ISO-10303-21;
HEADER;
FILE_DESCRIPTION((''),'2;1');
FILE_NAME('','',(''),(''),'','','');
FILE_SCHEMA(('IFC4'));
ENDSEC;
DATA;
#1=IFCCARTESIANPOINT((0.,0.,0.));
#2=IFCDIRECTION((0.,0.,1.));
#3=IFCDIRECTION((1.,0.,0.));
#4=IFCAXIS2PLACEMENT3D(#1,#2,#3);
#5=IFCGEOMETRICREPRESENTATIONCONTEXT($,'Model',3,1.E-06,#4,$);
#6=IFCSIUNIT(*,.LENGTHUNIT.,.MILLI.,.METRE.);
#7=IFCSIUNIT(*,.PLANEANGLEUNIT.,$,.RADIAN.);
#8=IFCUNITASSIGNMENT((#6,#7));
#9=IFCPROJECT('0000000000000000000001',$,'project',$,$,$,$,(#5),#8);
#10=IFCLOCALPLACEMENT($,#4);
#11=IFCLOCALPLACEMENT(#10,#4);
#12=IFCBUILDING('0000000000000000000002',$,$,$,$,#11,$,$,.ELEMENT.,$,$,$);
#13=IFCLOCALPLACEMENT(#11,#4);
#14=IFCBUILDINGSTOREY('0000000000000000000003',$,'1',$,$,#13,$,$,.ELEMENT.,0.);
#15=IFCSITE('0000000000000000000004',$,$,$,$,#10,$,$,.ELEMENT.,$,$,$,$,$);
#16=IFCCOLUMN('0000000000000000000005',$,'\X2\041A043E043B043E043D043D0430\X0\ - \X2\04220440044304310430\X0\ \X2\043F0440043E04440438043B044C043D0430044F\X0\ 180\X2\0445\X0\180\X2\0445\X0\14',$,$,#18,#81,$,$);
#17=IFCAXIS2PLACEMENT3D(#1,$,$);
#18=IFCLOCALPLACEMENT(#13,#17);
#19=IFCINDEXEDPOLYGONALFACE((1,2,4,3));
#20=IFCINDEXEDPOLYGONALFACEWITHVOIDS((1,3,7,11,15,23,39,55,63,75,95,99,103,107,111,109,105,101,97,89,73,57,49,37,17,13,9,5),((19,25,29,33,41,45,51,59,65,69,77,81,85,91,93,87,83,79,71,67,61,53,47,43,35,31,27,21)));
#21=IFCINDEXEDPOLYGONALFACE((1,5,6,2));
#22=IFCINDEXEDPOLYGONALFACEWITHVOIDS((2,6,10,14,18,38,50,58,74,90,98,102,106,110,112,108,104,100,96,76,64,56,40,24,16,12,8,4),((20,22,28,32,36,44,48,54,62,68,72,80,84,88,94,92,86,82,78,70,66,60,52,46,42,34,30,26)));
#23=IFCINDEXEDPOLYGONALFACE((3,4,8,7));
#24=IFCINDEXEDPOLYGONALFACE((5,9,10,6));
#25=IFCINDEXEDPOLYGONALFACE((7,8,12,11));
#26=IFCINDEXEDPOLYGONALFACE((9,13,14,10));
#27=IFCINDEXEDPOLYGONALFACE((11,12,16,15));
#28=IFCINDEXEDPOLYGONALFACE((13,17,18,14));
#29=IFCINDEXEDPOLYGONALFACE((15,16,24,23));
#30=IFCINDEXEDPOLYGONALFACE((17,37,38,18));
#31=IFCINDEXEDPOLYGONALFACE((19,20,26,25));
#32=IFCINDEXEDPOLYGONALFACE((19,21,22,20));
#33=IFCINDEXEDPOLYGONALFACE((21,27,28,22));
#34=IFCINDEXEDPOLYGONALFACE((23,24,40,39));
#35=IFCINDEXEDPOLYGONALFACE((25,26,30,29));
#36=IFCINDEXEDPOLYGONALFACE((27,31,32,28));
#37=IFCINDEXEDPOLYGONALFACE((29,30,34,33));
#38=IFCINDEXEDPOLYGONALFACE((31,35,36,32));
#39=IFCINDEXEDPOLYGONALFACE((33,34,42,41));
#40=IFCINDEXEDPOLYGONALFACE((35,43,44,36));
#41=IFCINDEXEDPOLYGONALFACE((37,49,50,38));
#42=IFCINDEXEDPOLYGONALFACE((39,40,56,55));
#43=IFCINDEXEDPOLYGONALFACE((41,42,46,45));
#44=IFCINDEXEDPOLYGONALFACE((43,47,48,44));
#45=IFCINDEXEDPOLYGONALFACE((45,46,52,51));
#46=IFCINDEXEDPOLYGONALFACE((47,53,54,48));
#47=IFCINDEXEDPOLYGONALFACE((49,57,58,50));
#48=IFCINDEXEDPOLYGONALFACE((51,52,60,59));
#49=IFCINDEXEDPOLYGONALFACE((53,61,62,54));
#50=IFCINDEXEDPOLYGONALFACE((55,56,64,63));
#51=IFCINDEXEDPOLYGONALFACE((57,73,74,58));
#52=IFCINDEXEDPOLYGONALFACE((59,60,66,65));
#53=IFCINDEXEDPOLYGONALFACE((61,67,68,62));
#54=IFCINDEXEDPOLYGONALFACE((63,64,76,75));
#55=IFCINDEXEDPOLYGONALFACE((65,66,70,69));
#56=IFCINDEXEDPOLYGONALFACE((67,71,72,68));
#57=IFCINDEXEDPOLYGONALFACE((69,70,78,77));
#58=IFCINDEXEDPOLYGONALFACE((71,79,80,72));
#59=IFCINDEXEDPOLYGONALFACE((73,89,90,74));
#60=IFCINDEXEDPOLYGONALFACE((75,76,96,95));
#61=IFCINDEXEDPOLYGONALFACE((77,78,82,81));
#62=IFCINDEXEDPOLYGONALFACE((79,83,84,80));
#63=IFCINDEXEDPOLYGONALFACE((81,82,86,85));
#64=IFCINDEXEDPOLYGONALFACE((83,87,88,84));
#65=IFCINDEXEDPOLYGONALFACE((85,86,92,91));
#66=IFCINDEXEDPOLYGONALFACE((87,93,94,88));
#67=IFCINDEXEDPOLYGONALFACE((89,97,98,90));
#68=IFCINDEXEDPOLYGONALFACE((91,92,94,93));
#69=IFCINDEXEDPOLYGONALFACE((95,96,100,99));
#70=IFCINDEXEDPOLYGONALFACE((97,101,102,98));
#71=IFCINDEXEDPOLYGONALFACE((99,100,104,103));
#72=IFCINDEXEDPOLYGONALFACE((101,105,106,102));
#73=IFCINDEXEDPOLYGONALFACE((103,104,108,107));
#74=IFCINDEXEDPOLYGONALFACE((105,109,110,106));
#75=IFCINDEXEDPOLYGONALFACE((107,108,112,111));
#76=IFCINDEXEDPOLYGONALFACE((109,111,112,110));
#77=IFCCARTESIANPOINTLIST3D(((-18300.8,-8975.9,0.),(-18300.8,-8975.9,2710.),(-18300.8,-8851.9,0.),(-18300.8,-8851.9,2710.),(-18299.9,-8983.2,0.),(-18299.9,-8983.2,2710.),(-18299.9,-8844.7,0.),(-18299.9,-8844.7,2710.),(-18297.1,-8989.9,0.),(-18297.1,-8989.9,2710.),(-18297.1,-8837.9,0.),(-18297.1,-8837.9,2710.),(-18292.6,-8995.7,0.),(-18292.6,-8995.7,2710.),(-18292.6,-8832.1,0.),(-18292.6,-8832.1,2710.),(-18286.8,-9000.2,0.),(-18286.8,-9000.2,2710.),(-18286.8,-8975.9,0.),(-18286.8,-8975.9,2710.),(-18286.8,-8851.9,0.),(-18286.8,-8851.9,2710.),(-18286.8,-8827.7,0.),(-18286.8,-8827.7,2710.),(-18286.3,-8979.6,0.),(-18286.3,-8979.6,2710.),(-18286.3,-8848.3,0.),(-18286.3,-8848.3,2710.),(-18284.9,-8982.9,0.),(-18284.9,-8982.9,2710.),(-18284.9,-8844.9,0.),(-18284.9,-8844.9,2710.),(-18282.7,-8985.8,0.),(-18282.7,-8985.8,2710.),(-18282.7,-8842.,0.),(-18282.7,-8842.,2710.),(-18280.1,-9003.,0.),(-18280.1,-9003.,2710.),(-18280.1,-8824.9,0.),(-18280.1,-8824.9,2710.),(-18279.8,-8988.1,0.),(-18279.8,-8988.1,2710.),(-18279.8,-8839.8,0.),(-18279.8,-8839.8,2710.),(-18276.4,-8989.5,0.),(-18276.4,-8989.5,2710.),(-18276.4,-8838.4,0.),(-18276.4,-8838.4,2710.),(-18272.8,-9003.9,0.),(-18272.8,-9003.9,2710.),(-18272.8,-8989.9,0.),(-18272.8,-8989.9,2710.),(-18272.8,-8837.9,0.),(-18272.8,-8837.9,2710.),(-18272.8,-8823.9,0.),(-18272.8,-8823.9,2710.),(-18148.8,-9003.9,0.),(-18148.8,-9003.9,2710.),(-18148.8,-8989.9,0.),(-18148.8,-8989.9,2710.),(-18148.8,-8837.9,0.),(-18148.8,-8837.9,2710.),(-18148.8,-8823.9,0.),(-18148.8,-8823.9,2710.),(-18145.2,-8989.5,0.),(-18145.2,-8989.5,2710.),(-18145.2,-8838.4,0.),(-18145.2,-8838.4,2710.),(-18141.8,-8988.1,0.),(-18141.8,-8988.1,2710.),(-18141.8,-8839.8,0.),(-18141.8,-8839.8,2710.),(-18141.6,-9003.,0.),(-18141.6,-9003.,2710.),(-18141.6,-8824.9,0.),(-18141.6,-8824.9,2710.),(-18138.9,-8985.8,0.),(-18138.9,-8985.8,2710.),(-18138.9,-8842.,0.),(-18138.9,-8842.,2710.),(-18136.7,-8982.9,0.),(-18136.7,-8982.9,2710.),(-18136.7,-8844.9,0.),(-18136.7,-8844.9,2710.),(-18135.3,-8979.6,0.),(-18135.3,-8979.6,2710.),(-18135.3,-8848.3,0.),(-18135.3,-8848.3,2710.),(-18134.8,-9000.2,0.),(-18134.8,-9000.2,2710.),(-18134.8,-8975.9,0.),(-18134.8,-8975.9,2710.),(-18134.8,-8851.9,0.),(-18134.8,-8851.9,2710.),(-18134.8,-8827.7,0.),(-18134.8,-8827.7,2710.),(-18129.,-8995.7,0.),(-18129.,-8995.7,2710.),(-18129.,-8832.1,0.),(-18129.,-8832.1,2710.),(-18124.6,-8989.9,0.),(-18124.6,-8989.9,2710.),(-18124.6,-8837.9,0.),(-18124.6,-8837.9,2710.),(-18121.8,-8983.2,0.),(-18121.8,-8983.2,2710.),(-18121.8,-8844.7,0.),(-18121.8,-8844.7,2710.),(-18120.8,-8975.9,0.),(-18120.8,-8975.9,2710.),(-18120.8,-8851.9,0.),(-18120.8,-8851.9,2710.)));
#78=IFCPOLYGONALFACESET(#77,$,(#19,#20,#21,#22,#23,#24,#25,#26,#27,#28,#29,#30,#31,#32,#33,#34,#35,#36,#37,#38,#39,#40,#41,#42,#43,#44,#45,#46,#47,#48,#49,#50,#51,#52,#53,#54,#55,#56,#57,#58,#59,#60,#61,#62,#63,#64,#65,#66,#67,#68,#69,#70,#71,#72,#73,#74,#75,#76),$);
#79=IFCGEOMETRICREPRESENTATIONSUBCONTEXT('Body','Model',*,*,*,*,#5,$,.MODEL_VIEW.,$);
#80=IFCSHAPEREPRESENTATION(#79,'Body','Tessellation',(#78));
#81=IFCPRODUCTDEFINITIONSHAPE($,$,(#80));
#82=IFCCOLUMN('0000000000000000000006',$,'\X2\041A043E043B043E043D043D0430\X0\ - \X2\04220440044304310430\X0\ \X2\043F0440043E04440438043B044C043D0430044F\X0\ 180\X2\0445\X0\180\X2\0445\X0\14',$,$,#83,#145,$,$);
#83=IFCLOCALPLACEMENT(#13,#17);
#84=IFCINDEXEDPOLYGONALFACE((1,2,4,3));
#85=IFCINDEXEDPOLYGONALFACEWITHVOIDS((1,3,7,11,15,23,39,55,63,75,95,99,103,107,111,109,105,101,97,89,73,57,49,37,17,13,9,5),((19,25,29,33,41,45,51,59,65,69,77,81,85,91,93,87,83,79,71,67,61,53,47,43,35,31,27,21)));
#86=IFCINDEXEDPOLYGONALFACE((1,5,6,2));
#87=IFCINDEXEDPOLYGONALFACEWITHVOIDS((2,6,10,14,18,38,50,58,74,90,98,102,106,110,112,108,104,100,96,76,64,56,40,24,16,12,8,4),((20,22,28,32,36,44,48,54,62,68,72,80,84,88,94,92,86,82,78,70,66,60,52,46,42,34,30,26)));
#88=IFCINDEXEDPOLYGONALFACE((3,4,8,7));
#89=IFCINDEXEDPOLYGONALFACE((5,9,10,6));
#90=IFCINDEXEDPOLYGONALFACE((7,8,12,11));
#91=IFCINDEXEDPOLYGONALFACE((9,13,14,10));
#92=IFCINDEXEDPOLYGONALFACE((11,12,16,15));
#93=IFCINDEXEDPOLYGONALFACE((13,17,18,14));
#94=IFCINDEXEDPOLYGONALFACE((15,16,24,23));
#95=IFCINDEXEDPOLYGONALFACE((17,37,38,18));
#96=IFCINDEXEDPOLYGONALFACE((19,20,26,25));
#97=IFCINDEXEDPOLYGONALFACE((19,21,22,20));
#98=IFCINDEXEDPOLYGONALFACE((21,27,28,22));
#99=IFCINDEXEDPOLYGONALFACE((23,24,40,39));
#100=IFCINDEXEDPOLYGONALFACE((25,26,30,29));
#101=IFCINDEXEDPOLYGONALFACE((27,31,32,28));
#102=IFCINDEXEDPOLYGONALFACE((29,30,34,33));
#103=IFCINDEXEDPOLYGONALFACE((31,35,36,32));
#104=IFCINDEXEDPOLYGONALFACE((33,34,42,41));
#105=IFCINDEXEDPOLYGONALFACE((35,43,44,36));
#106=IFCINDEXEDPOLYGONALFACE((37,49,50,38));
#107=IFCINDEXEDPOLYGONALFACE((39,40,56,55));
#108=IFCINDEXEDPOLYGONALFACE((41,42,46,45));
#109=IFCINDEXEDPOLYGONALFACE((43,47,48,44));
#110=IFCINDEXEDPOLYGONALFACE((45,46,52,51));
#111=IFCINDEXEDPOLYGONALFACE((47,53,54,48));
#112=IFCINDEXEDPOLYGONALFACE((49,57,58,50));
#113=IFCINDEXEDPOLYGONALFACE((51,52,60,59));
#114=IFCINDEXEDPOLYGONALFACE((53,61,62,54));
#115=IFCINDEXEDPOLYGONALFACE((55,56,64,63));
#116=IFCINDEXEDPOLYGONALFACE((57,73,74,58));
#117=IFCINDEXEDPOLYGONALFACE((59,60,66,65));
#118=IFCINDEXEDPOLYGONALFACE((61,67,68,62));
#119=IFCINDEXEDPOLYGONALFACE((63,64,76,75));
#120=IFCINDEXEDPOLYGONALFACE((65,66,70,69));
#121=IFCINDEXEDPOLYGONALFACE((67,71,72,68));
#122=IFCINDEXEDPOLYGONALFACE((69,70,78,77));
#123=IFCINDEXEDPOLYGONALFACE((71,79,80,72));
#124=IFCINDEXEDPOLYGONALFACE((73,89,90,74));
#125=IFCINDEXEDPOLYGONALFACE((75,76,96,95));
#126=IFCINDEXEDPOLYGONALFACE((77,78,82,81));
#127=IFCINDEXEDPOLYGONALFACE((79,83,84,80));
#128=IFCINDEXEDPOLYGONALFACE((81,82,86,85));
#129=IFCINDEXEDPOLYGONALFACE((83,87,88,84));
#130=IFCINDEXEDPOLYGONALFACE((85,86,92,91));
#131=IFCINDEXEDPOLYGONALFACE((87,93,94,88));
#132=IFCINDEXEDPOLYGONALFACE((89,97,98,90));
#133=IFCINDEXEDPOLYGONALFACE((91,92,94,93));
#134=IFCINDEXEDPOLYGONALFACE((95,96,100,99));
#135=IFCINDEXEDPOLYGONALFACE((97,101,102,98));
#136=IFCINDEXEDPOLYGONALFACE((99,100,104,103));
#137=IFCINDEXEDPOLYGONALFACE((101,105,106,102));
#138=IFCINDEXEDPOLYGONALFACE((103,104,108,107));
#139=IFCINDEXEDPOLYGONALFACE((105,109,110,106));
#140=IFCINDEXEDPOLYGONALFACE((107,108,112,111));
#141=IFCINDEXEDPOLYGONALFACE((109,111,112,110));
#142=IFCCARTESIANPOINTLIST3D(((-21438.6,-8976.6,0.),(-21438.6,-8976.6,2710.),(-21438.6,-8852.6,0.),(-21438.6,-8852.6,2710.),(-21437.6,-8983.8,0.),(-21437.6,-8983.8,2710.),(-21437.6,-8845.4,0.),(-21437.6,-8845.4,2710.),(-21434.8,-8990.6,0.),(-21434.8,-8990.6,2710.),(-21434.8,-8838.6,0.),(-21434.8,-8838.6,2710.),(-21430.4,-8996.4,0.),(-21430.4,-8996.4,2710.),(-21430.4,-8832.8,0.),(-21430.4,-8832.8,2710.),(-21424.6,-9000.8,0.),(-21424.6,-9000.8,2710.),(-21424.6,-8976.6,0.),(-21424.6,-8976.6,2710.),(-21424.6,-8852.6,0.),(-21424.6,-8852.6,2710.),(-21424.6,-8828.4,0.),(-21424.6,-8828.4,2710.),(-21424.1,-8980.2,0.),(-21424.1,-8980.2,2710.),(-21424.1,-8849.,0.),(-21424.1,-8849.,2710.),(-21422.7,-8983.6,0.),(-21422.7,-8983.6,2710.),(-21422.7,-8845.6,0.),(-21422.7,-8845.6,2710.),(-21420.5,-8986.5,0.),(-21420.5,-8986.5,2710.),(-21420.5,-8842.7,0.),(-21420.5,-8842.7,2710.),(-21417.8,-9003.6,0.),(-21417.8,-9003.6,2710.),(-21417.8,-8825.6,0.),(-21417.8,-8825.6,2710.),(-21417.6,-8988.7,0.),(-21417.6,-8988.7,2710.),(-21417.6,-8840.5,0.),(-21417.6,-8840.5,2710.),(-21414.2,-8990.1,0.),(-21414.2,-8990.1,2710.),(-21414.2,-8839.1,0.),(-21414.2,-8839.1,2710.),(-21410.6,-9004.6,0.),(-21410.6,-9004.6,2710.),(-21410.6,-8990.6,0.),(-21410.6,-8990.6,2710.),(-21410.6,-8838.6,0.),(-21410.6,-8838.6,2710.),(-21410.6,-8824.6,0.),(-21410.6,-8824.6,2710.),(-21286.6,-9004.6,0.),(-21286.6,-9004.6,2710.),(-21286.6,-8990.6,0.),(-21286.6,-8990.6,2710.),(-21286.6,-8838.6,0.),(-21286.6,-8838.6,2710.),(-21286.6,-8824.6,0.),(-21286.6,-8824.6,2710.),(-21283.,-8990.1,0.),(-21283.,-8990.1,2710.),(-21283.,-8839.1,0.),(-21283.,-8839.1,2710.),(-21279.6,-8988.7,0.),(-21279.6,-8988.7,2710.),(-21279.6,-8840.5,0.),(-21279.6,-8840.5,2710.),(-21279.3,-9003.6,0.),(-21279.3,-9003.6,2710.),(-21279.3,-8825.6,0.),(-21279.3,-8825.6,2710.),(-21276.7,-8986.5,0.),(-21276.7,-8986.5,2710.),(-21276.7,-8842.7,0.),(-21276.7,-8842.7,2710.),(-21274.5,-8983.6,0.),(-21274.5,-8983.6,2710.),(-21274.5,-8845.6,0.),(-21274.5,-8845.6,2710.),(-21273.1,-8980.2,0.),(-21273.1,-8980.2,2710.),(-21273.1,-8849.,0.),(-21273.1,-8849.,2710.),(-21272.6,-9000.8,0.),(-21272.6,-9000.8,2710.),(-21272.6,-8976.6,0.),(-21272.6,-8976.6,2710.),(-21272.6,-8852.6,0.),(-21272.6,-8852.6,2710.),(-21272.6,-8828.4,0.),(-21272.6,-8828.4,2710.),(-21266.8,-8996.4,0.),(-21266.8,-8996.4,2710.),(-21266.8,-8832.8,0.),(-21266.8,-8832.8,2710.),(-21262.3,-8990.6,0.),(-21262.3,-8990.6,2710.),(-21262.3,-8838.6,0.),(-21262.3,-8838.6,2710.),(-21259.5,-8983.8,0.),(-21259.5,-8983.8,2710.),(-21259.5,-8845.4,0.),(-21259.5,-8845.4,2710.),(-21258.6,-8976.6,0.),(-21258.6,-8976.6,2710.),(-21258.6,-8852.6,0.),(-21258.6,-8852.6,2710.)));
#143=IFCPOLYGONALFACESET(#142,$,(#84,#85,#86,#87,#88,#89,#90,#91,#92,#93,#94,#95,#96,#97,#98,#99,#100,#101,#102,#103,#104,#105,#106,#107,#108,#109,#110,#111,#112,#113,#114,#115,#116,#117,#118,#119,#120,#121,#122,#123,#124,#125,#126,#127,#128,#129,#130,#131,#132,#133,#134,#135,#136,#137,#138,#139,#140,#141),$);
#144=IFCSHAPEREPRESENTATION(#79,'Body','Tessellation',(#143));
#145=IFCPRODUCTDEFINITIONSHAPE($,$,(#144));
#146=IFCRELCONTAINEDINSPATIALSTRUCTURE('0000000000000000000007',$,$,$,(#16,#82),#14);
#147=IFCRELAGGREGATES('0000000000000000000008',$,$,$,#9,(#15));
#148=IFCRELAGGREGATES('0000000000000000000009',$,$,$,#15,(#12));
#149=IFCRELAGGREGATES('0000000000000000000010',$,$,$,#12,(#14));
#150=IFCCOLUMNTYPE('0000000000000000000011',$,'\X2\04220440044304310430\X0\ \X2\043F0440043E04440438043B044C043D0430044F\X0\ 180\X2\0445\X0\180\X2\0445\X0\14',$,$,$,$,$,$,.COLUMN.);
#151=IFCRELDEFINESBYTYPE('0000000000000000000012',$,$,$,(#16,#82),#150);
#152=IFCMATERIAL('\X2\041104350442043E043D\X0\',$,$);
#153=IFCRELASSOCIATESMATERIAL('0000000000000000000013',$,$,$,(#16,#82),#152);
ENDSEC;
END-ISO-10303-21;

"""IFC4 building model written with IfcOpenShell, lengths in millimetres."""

from ifc_helpers import new_model, si_unit, frame, origin_with_axes, place, context, subcontext, project, spatial, line, arc, indexed_curve, outline, extrude, source, transform, mapped, material, type_object, element, save


model = new_model("IFC4")

# Units and contexts
model_context = context("Model", 3, precision=1e-06, world=origin_with_axes())
body_context = subcontext(model_context, "Body", "Model", "MODEL_VIEW")
ifc_project = project(units=[si_unit("LENGTHUNIT", "METRE", prefix="MILLI"), si_unit("PLANEANGLEUNIT", "RADIAN")], contexts=[model_context])

# Site, building, storey
site_placement = place(None, origin_with_axes())
site = spatial("IfcSite", under=ifc_project, at=site_placement, CompositionType="ELEMENT")
building_placement = place(site_placement, origin_with_axes())
building = spatial("IfcBuilding", under=site, at=building_placement, CompositionType="ELEMENT")
storey_placement = place(building_placement, origin_with_axes())
storey = spatial("IfcBuildingStorey", under=building, at=storey_placement, Name="1", CompositionType="ELEMENT", Elevation=0.0)

# Columns
ifc_material = material(Name="Бетон")
column_type = type_object("IfcColumnType", Name="Труба профильная 180х180х14", PredefinedType="COLUMN")
shared_shape = source(origin_with_axes(), body_context, "Body", "SweptSolid", [
    extrude(outline(indexed_curve([(-90.0, -62.0), (-81.8, -81.8), (-62.0, -90.0), (62.0, -90.0), (81.8, -81.8), (90.0, -62.0), (90.0, 62.0), (81.8, 81.8), (62.0, 90.0), (-62.0, 90.0), (-81.8, 81.8), (-90.0, 62.0)], segments=[arc(1, 2, 3), line(3, 4), arc(4, 5, 6), line(6, 7), arc(7, 8, 9), line(9, 10), arc(10, 11, 12), line(12, 1)]), holes=[indexed_curve([(-76.0, 62.0), (-71.9, 71.9), (-62.0, 76.0), (62.0, 76.0), (71.9, 71.9), (76.0, 62.0), (76.0, -62.0), (71.9, -71.9), (62.0, -76.0), (-62.0, -76.0), (-71.9, -71.9), (-76.0, -62.0)], segments=[arc(1, 2, 3), line(3, 4), arc(4, 5, 6), line(6, 7), arc(7, 8, 9), line(9, 10), arc(10, 11, 12), line(12, 1)])]), origin_with_axes(), (0.0, 0.0, 1.0), 2710.0),
])
for number, where, z_axis, x_axis, name in (
    (1, (-18210.8, -8913.9, 0.0), (0.0, 0.0, 1.0), (1.0, 0.0, 0.0), "Колонна - Труба профильная 180х180х14"),
    (2, (-21348.6, -8914.6, 0.0), (0.0, 0.0, 1.0), (1.0, 0.0, 0.0), "Колонна - Труба профильная 180х180х14"),
):
    element("IfcColumn", number, at=place(storey_placement, frame(where, z_axis=z_axis, x_axis=x_axis)), inside=storey, type_object=column_type, material=ifc_material, Name=name, context=body_context, shape_type="MappedRepresentation", body=[
        mapped(shared_shape, transform((0.0, 0.0, 0.0), x_axis=(1.0, 0.0, 0.0), y_axis=(0.0, 1.0, 0.0), z_axis=(0.0, 0.0, 1.0), scale=1.0)),
    ])

save(model, "model.ifc")
